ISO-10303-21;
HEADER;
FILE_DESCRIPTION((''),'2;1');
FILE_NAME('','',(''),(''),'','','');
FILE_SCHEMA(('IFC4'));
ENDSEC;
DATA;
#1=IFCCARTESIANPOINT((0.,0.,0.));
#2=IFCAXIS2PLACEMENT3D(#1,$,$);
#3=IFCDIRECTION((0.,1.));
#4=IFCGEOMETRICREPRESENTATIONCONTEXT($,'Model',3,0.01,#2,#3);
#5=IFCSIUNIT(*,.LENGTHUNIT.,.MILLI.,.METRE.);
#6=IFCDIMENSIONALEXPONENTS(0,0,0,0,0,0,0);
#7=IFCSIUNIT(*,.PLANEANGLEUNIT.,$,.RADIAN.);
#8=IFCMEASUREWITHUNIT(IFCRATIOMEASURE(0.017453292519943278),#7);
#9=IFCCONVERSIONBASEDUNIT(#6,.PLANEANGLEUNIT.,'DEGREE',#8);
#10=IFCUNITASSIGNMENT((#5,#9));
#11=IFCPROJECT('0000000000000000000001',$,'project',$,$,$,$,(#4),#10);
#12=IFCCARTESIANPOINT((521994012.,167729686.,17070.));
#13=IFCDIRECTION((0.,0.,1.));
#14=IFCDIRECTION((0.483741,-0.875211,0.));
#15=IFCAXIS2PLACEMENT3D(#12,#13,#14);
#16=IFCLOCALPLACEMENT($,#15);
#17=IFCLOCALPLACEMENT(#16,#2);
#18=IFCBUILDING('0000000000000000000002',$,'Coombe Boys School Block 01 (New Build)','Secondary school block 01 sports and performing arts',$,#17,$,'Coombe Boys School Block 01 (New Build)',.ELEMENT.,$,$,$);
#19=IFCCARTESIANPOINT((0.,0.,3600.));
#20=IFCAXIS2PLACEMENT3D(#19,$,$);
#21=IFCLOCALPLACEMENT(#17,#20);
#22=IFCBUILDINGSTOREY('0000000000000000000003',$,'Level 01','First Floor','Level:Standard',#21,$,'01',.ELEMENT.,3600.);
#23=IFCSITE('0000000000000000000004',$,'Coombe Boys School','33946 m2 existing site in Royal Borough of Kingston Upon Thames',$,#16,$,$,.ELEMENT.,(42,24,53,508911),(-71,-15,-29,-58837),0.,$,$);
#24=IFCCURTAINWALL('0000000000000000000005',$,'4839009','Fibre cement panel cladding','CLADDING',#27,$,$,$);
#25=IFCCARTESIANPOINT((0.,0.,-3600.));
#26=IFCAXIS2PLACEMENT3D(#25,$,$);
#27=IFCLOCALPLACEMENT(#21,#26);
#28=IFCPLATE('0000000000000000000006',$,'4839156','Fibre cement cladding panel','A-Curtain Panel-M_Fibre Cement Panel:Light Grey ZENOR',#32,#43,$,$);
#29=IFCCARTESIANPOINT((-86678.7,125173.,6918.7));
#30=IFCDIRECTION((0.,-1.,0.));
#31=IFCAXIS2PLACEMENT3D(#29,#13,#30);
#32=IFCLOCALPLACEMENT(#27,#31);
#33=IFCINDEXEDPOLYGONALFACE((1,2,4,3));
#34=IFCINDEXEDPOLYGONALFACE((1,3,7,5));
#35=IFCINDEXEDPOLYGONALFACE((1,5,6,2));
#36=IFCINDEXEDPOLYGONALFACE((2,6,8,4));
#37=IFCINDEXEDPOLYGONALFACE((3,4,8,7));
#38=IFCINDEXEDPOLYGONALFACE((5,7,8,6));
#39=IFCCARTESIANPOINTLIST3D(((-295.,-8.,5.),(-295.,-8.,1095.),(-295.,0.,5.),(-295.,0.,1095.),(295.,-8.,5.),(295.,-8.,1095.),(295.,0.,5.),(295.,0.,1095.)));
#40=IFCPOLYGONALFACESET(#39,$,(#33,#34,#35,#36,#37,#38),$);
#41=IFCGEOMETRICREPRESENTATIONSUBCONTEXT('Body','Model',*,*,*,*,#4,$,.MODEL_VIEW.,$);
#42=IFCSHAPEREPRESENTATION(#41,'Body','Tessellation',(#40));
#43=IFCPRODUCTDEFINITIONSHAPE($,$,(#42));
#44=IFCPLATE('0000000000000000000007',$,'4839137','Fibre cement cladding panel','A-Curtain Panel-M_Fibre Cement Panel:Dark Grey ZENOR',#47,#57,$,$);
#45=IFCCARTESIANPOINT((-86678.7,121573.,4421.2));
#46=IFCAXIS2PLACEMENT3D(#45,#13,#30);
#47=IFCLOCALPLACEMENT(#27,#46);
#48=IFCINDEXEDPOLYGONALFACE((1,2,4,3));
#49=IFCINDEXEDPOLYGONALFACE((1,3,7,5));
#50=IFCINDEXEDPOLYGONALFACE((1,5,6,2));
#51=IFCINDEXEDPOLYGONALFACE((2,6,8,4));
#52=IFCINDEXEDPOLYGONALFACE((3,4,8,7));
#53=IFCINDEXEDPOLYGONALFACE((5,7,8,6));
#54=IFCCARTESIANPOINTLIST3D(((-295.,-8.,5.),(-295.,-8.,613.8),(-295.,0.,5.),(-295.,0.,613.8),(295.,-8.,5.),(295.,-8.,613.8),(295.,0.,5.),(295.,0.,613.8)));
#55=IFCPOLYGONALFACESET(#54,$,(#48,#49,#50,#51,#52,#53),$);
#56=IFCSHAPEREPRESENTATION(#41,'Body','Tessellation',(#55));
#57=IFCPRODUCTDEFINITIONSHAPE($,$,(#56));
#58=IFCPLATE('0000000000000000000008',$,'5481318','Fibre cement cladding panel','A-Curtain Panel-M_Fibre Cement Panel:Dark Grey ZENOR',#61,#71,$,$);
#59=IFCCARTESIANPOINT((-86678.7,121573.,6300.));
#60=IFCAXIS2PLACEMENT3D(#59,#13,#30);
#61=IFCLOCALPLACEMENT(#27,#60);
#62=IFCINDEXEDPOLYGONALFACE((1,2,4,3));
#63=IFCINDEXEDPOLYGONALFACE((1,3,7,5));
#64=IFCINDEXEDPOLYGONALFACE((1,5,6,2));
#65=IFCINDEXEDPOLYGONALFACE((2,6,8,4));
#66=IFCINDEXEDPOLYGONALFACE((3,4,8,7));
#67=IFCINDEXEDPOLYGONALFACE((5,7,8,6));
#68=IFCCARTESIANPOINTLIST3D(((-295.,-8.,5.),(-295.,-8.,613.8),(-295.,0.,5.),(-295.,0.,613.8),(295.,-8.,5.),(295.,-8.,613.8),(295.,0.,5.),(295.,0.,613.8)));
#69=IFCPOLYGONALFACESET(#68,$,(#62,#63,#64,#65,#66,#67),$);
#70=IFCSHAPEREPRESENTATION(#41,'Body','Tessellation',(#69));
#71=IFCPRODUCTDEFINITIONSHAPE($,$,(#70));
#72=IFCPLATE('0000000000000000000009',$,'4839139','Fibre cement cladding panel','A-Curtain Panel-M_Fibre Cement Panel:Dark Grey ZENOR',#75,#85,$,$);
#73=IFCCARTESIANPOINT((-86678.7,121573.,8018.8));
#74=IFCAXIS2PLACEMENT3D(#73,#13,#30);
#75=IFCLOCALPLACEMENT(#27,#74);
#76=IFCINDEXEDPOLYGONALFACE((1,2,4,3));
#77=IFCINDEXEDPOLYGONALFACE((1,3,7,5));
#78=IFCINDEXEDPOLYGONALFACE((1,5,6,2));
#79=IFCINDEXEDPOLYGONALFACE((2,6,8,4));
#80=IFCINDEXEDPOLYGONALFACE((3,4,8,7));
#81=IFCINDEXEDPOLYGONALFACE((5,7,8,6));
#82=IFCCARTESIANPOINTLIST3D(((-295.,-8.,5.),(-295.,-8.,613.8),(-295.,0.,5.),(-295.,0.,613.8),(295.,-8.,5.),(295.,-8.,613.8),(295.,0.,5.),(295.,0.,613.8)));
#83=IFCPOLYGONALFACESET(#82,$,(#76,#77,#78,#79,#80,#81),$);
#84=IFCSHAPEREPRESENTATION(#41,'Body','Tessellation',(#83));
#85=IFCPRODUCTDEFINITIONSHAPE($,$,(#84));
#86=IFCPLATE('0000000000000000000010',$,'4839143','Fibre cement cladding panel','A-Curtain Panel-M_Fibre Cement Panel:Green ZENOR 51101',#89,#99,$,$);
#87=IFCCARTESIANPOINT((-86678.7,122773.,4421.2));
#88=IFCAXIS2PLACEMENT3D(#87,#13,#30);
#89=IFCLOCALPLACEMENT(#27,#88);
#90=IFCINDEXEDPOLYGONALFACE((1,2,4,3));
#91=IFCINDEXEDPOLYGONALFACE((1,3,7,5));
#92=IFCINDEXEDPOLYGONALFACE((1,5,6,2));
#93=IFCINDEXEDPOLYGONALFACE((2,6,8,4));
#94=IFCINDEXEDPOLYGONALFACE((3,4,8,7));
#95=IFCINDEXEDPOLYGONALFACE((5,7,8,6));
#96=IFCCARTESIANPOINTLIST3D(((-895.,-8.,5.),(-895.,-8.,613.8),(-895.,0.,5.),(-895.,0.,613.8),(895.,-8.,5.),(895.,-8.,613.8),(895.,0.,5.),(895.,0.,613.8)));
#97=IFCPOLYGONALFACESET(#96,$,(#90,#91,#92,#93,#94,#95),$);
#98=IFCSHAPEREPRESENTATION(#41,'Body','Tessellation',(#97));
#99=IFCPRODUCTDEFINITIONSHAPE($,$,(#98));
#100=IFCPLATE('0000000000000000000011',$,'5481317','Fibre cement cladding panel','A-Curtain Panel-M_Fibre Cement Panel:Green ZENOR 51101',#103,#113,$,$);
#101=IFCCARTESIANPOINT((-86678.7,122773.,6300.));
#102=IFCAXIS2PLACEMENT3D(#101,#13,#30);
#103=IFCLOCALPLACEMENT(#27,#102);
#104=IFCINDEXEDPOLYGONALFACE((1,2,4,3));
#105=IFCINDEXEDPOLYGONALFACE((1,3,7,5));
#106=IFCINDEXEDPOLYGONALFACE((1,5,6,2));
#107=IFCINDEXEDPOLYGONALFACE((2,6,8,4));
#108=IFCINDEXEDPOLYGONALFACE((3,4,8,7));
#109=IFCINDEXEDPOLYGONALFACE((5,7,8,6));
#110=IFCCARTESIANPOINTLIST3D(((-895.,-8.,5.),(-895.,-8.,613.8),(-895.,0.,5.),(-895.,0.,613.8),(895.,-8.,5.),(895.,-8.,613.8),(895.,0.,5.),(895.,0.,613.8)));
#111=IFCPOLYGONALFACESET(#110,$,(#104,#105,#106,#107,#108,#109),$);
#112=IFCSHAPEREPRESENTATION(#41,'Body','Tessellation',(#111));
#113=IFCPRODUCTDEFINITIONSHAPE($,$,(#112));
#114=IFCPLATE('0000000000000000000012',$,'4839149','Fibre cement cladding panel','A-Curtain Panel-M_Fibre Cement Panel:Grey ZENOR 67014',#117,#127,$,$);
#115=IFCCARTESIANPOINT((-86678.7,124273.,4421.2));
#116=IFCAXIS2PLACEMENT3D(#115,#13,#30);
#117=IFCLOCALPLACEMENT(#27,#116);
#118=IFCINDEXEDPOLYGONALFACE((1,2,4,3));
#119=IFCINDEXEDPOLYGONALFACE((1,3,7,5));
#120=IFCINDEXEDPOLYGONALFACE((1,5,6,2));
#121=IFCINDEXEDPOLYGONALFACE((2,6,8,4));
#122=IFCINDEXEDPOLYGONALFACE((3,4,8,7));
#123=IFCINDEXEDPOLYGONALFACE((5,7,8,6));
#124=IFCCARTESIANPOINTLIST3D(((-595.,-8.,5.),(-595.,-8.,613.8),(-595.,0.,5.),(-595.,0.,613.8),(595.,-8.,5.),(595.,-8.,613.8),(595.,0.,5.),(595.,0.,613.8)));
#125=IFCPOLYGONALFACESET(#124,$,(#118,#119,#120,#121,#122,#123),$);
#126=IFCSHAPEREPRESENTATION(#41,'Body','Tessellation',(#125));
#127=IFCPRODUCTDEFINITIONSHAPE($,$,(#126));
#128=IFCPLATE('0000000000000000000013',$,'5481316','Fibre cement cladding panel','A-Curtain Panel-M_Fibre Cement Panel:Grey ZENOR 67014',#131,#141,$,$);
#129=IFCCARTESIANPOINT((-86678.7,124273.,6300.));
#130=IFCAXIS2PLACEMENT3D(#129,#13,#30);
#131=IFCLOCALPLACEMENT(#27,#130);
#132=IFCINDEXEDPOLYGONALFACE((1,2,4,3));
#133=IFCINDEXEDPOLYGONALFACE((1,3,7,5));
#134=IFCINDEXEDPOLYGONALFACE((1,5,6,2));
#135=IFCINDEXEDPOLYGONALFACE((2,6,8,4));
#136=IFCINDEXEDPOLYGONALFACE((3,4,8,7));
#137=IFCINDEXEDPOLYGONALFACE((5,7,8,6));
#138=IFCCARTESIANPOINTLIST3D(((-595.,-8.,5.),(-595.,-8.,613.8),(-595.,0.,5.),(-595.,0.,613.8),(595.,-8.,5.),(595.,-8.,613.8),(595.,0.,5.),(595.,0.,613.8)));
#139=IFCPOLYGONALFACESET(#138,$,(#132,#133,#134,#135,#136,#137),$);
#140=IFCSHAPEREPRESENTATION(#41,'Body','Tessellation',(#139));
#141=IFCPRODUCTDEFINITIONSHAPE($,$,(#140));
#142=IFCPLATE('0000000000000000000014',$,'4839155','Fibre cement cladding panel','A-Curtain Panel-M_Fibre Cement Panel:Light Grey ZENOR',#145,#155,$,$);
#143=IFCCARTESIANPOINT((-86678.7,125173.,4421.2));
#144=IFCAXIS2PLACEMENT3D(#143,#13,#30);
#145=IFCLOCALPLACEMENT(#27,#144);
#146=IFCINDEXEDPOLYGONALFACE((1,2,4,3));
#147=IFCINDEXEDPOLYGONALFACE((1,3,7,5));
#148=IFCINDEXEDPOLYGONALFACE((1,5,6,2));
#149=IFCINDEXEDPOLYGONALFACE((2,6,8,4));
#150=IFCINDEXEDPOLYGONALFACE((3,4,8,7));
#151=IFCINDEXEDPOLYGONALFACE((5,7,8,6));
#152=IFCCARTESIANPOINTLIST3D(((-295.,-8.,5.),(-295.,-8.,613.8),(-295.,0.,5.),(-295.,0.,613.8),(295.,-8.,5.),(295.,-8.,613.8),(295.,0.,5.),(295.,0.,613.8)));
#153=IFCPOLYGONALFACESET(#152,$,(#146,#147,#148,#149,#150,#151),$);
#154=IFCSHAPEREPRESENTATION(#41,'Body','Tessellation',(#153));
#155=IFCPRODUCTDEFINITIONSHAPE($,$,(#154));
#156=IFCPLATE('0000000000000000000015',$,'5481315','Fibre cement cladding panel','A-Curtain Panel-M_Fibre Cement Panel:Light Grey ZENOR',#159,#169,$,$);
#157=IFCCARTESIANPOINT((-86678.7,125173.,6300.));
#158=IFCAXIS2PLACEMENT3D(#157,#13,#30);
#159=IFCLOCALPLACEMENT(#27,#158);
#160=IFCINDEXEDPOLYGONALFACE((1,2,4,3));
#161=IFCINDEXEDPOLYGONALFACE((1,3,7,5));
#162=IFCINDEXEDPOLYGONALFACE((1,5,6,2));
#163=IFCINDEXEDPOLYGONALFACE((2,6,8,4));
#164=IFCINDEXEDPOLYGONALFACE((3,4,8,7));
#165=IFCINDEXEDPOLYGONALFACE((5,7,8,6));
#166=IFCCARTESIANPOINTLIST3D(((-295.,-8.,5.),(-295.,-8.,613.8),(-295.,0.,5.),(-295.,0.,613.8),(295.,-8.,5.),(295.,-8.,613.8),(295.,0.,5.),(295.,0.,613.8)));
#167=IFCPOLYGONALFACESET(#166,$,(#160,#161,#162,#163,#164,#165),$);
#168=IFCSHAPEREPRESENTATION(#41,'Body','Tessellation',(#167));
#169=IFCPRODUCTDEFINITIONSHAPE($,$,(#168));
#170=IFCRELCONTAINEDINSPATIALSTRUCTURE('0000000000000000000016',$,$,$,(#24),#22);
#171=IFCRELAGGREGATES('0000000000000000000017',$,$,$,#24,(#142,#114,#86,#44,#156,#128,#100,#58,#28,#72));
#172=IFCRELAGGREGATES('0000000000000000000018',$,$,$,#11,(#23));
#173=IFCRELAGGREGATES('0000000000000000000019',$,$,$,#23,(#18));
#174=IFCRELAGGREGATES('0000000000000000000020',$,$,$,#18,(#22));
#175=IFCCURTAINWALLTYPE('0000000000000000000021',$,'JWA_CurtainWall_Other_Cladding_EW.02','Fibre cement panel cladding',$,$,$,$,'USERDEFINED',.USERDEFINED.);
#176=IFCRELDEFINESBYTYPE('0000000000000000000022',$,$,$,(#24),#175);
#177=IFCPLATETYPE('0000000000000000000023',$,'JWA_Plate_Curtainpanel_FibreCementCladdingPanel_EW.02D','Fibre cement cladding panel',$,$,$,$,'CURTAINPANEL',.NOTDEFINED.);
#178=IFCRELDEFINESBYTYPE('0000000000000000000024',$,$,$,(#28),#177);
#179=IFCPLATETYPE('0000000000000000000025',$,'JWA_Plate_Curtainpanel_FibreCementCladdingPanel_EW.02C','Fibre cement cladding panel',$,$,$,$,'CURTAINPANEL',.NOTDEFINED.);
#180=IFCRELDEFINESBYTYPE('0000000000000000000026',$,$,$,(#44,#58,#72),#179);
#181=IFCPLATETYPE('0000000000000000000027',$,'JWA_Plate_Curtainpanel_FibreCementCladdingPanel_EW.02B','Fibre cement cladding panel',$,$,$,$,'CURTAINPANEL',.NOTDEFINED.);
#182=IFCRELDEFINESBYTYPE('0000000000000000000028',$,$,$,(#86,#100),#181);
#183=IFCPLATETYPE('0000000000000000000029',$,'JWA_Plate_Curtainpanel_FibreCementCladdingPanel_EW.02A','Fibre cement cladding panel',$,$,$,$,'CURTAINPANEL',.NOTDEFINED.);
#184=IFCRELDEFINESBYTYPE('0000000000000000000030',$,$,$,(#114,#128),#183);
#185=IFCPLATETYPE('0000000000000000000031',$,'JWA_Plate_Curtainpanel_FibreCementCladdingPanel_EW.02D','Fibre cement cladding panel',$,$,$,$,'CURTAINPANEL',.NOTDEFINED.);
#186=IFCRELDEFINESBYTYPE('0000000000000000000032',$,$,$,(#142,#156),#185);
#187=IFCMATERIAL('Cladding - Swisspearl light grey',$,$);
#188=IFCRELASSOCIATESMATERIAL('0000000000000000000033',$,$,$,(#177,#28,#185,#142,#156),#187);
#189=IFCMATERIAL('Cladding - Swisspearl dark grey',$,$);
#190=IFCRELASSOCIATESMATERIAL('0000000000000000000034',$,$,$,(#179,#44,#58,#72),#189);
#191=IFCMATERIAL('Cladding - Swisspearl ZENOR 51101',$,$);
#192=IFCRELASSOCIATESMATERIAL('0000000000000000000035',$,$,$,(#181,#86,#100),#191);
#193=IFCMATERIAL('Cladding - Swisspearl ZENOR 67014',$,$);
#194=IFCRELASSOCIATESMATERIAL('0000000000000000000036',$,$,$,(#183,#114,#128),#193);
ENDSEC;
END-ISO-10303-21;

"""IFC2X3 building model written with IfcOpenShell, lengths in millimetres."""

from ifc_helpers import new_model, entity, si_unit, converted_unit, direction, frame, origin, origin_2d_with_axis, place, context, subcontext, project, spatial, rectangle, extrude, source, transform, mapped, material, type_object, type_shapes, element, aggregate, save


model = new_model("IFC2X3")

# Units and contexts
model_context = context("Model", 3, precision=0.01, world=origin(), true_north=direction((0.0, 1.0)))
body_context = subcontext(model_context, "Body", "Model", "MODEL_VIEW")
ifc_project = project(units=[si_unit("LENGTHUNIT", "METRE", prefix="MILLI"), converted_unit("PLANEANGLEUNIT", "DEGREE", entity("IfcRatioMeasure", 0.017453292519943278), si_unit("PLANEANGLEUNIT", "RADIAN"), dimensions=[0, 0, 0, 0, 0, 0, 0])], contexts=[model_context])

# Site, building, storey
site_placement = place(None, frame((521994012.0, 167729686.0, 17070.0), z_axis=(0.0, 0.0, 1.0), x_axis=(0.483741, -0.875211, 0.0)))
site = spatial("IfcSite", under=ifc_project, at=site_placement, Name="Coombe Boys School", Description="33946 m2 existing site in Royal Borough of Kingston Upon Thames", CompositionType="ELEMENT", RefLatitude=(42, 24, 53, 508911), RefLongitude=(-71, -15, -29, -58837), RefElevation=0.0)
building_placement = place(site_placement, origin())
building = spatial("IfcBuilding", under=site, at=building_placement, Name="Coombe Boys School Block 01 (New Build)", Description="Secondary school block 01 sports and performing arts", LongName="Coombe Boys School Block 01 (New Build)", CompositionType="ELEMENT")
storey_placement = place(building_placement, frame((0.0, 0.0, 3600.0)))
storey = spatial("IfcBuildingStorey", under=building, at=storey_placement, Name="Level 01", Description="First Floor", ObjectType="Level:Standard", LongName="01", CompositionType="ELEMENT", Elevation=3600.0)

# Curtain wall, plates
curtain_wall_type = type_object("IfcCurtainWallType", Name="JWA_CurtainWall_Other_Cladding_EW.02", Description="Fibre cement panel cladding", ElementType="USERDEFINED", PredefinedType="USERDEFINED")
curtain_wall_placement = place(storey_placement, frame((0.0, 0.0, -3600.0)))
curtain_wall = element("IfcCurtainWall", 1, at=curtain_wall_placement, inside=storey, type_object=curtain_wall_type, Name="4839009", Description="Fibre cement panel cladding", ObjectType="CLADDING")
ifc_material_1 = material(Name="Cladding - Swisspearl dark grey")
ifc_material_2 = material(Name="Cladding - Swisspearl ZENOR 51101")
ifc_material_3 = material(Name="Cladding - Swisspearl ZENOR 67014")
ifc_material_4 = material(Name="Cladding - Swisspearl light grey")
plate_type_1 = type_object("IfcPlateType", Name="JWA_Plate_Curtainpanel_FibreCementCladdingPanel_EW.02D", Description="Fibre cement cladding panel", ElementType="CURTAINPANEL", PredefinedType="NOTDEFINED", material=ifc_material_4)
shared_shape_1 = source(origin(), body_context, "Body", "SweptSolid", [
    extrude(rectangle(XDim=590.0, YDim=8.0, at=origin_2d_with_axis()), frame((0.0, -4.0, 5.0), z_axis=(0.0, 0.0, 1.0), x_axis=(-1.0, 0.0, 0.0)), (0.0, 0.0, 1.0), 1090.0),
])
type_shapes(plate_type_1, [shared_shape_1])
plate_1_placement = place(curtain_wall_placement, frame((-86678.7, 125173.0, 6918.7), z_axis=(0.0, 0.0, 1.0), x_axis=(0.0, -1.0, 0.0)))
plate_1 = element("IfcPlate", 2, at=plate_1_placement, type_object=plate_type_1, material=ifc_material_4, Name="4839156", Description="Fibre cement cladding panel", ObjectType="A-Curtain Panel-M_Fibre Cement Panel:Light Grey ZENOR", context=body_context, shape_type="MappedRepresentation", body=[
    mapped(shared_shape_1, transform((0.0, 0.0, 0.0), scale=1.0)),
])
plate_type_2 = type_object("IfcPlateType", Name="JWA_Plate_Curtainpanel_FibreCementCladdingPanel_EW.02C", Description="Fibre cement cladding panel", ElementType="CURTAINPANEL", PredefinedType="NOTDEFINED", material=ifc_material_1)
shared_shape_2 = source(origin(), body_context, "Body", "SweptSolid", [
    extrude(rectangle(XDim=590.0, YDim=8.0, at=origin_2d_with_axis()), frame((0.0, -4.0, 5.0), z_axis=(0.0, 0.0, 1.0), x_axis=(-1.0, 0.0, 0.0)), (0.0, 0.0, 1.0), 608.8),
])
type_shapes(plate_type_2, [shared_shape_2])
plate_2_placement = place(curtain_wall_placement, frame((-86678.7, 121573.0, 4421.2), z_axis=(0.0, 0.0, 1.0), x_axis=(0.0, -1.0, 0.0)))
plate_2 = element("IfcPlate", 3, at=plate_2_placement, type_object=plate_type_2, material=ifc_material_1, Name="4839137", Description="Fibre cement cladding panel", ObjectType="A-Curtain Panel-M_Fibre Cement Panel:Dark Grey ZENOR", context=body_context, shape_type="MappedRepresentation", body=[
    mapped(shared_shape_2, transform((0.0, 0.0, 0.0), scale=1.0)),
])
plate_3_placement = place(curtain_wall_placement, frame((-86678.7, 121573.0, 6300.0), z_axis=(0.0, 0.0, 1.0), x_axis=(0.0, -1.0, 0.0)))
plate_3 = element("IfcPlate", 4, at=plate_3_placement, type_object=plate_type_2, material=ifc_material_1, Name="5481318", Description="Fibre cement cladding panel", ObjectType="A-Curtain Panel-M_Fibre Cement Panel:Dark Grey ZENOR", context=body_context, shape_type="MappedRepresentation", body=[
    mapped(shared_shape_2, transform((0.0, 0.0, 0.0), scale=1.0)),
])
plate_4_placement = place(curtain_wall_placement, frame((-86678.7, 121573.0, 8018.8), z_axis=(0.0, 0.0, 1.0), x_axis=(0.0, -1.0, 0.0)))
plate_4 = element("IfcPlate", 5, at=plate_4_placement, type_object=plate_type_2, material=ifc_material_1, Name="4839139", Description="Fibre cement cladding panel", ObjectType="A-Curtain Panel-M_Fibre Cement Panel:Dark Grey ZENOR", context=body_context, shape_type="MappedRepresentation", body=[
    mapped(shared_shape_2, transform((0.0, 0.0, 0.0), scale=1.0)),
])
plate_type_3 = type_object("IfcPlateType", Name="JWA_Plate_Curtainpanel_FibreCementCladdingPanel_EW.02B", Description="Fibre cement cladding panel", ElementType="CURTAINPANEL", PredefinedType="NOTDEFINED", material=ifc_material_2)
shared_shape_3 = source(origin(), body_context, "Body", "SweptSolid", [
    extrude(rectangle(XDim=1790.0, YDim=8.0, at=origin_2d_with_axis()), frame((0.0, -4.0, 5.0), z_axis=(0.0, 0.0, 1.0), x_axis=(-1.0, 0.0, 0.0)), (0.0, 0.0, 1.0), 608.8),
])
type_shapes(plate_type_3, [shared_shape_3])
plate_5_placement = place(curtain_wall_placement, frame((-86678.7, 122773.0, 4421.2), z_axis=(0.0, 0.0, 1.0), x_axis=(0.0, -1.0, 0.0)))
plate_5 = element("IfcPlate", 6, at=plate_5_placement, type_object=plate_type_3, material=ifc_material_2, Name="4839143", Description="Fibre cement cladding panel", ObjectType="A-Curtain Panel-M_Fibre Cement Panel:Green ZENOR 51101", context=body_context, shape_type="MappedRepresentation", body=[
    mapped(shared_shape_3, transform((0.0, 0.0, 0.0), scale=1.0)),
])
plate_6_placement = place(curtain_wall_placement, frame((-86678.7, 122773.0, 6300.0), z_axis=(0.0, 0.0, 1.0), x_axis=(0.0, -1.0, 0.0)))
plate_6 = element("IfcPlate", 7, at=plate_6_placement, type_object=plate_type_3, material=ifc_material_2, Name="5481317", Description="Fibre cement cladding panel", ObjectType="A-Curtain Panel-M_Fibre Cement Panel:Green ZENOR 51101", context=body_context, shape_type="MappedRepresentation", body=[
    mapped(shared_shape_3, transform((0.0, 0.0, 0.0), scale=1.0)),
])
plate_type_4 = type_object("IfcPlateType", Name="JWA_Plate_Curtainpanel_FibreCementCladdingPanel_EW.02A", Description="Fibre cement cladding panel", ElementType="CURTAINPANEL", PredefinedType="NOTDEFINED", material=ifc_material_3)
shared_shape_4 = source(origin(), body_context, "Body", "SweptSolid", [
    extrude(rectangle(XDim=1190.0, YDim=8.0, at=origin_2d_with_axis()), frame((0.0, -4.0, 5.0), z_axis=(0.0, 0.0, 1.0), x_axis=(-1.0, 0.0, 0.0)), (0.0, 0.0, 1.0), 608.8),
])
type_shapes(plate_type_4, [shared_shape_4])
plate_7_placement = place(curtain_wall_placement, frame((-86678.7, 124273.0, 4421.2), z_axis=(0.0, 0.0, 1.0), x_axis=(0.0, -1.0, 0.0)))
plate_7 = element("IfcPlate", 8, at=plate_7_placement, type_object=plate_type_4, material=ifc_material_3, Name="4839149", Description="Fibre cement cladding panel", ObjectType="A-Curtain Panel-M_Fibre Cement Panel:Grey ZENOR 67014", context=body_context, shape_type="MappedRepresentation", body=[
    mapped(shared_shape_4, transform((0.0, 0.0, 0.0), scale=1.0)),
])
plate_8_placement = place(curtain_wall_placement, frame((-86678.7, 124273.0, 6300.0), z_axis=(0.0, 0.0, 1.0), x_axis=(0.0, -1.0, 0.0)))
plate_8 = element("IfcPlate", 9, at=plate_8_placement, type_object=plate_type_4, material=ifc_material_3, Name="5481316", Description="Fibre cement cladding panel", ObjectType="A-Curtain Panel-M_Fibre Cement Panel:Grey ZENOR 67014", context=body_context, shape_type="MappedRepresentation", body=[
    mapped(shared_shape_4, transform((0.0, 0.0, 0.0), scale=1.0)),
])
plate_type_5 = type_object("IfcPlateType", Name="JWA_Plate_Curtainpanel_FibreCementCladdingPanel_EW.02D", Description="Fibre cement cladding panel", ElementType="CURTAINPANEL", PredefinedType="NOTDEFINED", material=ifc_material_4)
shared_shape_5 = source(origin(), body_context, "Body", "SweptSolid", [
    extrude(rectangle(XDim=590.0, YDim=8.0, at=origin_2d_with_axis()), frame((0.0, -4.0, 5.0), z_axis=(0.0, 0.0, 1.0), x_axis=(-1.0, 0.0, 0.0)), (0.0, 0.0, 1.0), 608.8),
])
type_shapes(plate_type_5, [shared_shape_5])
plate_9_placement = place(curtain_wall_placement, frame((-86678.7, 125173.0, 4421.2), z_axis=(0.0, 0.0, 1.0), x_axis=(0.0, -1.0, 0.0)))
plate_9 = element("IfcPlate", 10, at=plate_9_placement, type_object=plate_type_5, material=ifc_material_4, Name="4839155", Description="Fibre cement cladding panel", ObjectType="A-Curtain Panel-M_Fibre Cement Panel:Light Grey ZENOR", context=body_context, shape_type="MappedRepresentation", body=[
    mapped(shared_shape_5, transform((0.0, 0.0, 0.0), scale=1.0)),
])
plate_10_placement = place(curtain_wall_placement, frame((-86678.7, 125173.0, 6300.0), z_axis=(0.0, 0.0, 1.0), x_axis=(0.0, -1.0, 0.0)))
plate_10 = element("IfcPlate", 11, at=plate_10_placement, type_object=plate_type_5, material=ifc_material_4, Name="5481315", Description="Fibre cement cladding panel", ObjectType="A-Curtain Panel-M_Fibre Cement Panel:Light Grey ZENOR", context=body_context, shape_type="MappedRepresentation", body=[
    mapped(shared_shape_5, transform((0.0, 0.0, 0.0), scale=1.0)),
])
aggregate(curtain_wall, [plate_9, plate_7, plate_5, plate_2, plate_10, plate_8, plate_6, plate_3, plate_1, plate_4])

save(model, "model.ifc")
